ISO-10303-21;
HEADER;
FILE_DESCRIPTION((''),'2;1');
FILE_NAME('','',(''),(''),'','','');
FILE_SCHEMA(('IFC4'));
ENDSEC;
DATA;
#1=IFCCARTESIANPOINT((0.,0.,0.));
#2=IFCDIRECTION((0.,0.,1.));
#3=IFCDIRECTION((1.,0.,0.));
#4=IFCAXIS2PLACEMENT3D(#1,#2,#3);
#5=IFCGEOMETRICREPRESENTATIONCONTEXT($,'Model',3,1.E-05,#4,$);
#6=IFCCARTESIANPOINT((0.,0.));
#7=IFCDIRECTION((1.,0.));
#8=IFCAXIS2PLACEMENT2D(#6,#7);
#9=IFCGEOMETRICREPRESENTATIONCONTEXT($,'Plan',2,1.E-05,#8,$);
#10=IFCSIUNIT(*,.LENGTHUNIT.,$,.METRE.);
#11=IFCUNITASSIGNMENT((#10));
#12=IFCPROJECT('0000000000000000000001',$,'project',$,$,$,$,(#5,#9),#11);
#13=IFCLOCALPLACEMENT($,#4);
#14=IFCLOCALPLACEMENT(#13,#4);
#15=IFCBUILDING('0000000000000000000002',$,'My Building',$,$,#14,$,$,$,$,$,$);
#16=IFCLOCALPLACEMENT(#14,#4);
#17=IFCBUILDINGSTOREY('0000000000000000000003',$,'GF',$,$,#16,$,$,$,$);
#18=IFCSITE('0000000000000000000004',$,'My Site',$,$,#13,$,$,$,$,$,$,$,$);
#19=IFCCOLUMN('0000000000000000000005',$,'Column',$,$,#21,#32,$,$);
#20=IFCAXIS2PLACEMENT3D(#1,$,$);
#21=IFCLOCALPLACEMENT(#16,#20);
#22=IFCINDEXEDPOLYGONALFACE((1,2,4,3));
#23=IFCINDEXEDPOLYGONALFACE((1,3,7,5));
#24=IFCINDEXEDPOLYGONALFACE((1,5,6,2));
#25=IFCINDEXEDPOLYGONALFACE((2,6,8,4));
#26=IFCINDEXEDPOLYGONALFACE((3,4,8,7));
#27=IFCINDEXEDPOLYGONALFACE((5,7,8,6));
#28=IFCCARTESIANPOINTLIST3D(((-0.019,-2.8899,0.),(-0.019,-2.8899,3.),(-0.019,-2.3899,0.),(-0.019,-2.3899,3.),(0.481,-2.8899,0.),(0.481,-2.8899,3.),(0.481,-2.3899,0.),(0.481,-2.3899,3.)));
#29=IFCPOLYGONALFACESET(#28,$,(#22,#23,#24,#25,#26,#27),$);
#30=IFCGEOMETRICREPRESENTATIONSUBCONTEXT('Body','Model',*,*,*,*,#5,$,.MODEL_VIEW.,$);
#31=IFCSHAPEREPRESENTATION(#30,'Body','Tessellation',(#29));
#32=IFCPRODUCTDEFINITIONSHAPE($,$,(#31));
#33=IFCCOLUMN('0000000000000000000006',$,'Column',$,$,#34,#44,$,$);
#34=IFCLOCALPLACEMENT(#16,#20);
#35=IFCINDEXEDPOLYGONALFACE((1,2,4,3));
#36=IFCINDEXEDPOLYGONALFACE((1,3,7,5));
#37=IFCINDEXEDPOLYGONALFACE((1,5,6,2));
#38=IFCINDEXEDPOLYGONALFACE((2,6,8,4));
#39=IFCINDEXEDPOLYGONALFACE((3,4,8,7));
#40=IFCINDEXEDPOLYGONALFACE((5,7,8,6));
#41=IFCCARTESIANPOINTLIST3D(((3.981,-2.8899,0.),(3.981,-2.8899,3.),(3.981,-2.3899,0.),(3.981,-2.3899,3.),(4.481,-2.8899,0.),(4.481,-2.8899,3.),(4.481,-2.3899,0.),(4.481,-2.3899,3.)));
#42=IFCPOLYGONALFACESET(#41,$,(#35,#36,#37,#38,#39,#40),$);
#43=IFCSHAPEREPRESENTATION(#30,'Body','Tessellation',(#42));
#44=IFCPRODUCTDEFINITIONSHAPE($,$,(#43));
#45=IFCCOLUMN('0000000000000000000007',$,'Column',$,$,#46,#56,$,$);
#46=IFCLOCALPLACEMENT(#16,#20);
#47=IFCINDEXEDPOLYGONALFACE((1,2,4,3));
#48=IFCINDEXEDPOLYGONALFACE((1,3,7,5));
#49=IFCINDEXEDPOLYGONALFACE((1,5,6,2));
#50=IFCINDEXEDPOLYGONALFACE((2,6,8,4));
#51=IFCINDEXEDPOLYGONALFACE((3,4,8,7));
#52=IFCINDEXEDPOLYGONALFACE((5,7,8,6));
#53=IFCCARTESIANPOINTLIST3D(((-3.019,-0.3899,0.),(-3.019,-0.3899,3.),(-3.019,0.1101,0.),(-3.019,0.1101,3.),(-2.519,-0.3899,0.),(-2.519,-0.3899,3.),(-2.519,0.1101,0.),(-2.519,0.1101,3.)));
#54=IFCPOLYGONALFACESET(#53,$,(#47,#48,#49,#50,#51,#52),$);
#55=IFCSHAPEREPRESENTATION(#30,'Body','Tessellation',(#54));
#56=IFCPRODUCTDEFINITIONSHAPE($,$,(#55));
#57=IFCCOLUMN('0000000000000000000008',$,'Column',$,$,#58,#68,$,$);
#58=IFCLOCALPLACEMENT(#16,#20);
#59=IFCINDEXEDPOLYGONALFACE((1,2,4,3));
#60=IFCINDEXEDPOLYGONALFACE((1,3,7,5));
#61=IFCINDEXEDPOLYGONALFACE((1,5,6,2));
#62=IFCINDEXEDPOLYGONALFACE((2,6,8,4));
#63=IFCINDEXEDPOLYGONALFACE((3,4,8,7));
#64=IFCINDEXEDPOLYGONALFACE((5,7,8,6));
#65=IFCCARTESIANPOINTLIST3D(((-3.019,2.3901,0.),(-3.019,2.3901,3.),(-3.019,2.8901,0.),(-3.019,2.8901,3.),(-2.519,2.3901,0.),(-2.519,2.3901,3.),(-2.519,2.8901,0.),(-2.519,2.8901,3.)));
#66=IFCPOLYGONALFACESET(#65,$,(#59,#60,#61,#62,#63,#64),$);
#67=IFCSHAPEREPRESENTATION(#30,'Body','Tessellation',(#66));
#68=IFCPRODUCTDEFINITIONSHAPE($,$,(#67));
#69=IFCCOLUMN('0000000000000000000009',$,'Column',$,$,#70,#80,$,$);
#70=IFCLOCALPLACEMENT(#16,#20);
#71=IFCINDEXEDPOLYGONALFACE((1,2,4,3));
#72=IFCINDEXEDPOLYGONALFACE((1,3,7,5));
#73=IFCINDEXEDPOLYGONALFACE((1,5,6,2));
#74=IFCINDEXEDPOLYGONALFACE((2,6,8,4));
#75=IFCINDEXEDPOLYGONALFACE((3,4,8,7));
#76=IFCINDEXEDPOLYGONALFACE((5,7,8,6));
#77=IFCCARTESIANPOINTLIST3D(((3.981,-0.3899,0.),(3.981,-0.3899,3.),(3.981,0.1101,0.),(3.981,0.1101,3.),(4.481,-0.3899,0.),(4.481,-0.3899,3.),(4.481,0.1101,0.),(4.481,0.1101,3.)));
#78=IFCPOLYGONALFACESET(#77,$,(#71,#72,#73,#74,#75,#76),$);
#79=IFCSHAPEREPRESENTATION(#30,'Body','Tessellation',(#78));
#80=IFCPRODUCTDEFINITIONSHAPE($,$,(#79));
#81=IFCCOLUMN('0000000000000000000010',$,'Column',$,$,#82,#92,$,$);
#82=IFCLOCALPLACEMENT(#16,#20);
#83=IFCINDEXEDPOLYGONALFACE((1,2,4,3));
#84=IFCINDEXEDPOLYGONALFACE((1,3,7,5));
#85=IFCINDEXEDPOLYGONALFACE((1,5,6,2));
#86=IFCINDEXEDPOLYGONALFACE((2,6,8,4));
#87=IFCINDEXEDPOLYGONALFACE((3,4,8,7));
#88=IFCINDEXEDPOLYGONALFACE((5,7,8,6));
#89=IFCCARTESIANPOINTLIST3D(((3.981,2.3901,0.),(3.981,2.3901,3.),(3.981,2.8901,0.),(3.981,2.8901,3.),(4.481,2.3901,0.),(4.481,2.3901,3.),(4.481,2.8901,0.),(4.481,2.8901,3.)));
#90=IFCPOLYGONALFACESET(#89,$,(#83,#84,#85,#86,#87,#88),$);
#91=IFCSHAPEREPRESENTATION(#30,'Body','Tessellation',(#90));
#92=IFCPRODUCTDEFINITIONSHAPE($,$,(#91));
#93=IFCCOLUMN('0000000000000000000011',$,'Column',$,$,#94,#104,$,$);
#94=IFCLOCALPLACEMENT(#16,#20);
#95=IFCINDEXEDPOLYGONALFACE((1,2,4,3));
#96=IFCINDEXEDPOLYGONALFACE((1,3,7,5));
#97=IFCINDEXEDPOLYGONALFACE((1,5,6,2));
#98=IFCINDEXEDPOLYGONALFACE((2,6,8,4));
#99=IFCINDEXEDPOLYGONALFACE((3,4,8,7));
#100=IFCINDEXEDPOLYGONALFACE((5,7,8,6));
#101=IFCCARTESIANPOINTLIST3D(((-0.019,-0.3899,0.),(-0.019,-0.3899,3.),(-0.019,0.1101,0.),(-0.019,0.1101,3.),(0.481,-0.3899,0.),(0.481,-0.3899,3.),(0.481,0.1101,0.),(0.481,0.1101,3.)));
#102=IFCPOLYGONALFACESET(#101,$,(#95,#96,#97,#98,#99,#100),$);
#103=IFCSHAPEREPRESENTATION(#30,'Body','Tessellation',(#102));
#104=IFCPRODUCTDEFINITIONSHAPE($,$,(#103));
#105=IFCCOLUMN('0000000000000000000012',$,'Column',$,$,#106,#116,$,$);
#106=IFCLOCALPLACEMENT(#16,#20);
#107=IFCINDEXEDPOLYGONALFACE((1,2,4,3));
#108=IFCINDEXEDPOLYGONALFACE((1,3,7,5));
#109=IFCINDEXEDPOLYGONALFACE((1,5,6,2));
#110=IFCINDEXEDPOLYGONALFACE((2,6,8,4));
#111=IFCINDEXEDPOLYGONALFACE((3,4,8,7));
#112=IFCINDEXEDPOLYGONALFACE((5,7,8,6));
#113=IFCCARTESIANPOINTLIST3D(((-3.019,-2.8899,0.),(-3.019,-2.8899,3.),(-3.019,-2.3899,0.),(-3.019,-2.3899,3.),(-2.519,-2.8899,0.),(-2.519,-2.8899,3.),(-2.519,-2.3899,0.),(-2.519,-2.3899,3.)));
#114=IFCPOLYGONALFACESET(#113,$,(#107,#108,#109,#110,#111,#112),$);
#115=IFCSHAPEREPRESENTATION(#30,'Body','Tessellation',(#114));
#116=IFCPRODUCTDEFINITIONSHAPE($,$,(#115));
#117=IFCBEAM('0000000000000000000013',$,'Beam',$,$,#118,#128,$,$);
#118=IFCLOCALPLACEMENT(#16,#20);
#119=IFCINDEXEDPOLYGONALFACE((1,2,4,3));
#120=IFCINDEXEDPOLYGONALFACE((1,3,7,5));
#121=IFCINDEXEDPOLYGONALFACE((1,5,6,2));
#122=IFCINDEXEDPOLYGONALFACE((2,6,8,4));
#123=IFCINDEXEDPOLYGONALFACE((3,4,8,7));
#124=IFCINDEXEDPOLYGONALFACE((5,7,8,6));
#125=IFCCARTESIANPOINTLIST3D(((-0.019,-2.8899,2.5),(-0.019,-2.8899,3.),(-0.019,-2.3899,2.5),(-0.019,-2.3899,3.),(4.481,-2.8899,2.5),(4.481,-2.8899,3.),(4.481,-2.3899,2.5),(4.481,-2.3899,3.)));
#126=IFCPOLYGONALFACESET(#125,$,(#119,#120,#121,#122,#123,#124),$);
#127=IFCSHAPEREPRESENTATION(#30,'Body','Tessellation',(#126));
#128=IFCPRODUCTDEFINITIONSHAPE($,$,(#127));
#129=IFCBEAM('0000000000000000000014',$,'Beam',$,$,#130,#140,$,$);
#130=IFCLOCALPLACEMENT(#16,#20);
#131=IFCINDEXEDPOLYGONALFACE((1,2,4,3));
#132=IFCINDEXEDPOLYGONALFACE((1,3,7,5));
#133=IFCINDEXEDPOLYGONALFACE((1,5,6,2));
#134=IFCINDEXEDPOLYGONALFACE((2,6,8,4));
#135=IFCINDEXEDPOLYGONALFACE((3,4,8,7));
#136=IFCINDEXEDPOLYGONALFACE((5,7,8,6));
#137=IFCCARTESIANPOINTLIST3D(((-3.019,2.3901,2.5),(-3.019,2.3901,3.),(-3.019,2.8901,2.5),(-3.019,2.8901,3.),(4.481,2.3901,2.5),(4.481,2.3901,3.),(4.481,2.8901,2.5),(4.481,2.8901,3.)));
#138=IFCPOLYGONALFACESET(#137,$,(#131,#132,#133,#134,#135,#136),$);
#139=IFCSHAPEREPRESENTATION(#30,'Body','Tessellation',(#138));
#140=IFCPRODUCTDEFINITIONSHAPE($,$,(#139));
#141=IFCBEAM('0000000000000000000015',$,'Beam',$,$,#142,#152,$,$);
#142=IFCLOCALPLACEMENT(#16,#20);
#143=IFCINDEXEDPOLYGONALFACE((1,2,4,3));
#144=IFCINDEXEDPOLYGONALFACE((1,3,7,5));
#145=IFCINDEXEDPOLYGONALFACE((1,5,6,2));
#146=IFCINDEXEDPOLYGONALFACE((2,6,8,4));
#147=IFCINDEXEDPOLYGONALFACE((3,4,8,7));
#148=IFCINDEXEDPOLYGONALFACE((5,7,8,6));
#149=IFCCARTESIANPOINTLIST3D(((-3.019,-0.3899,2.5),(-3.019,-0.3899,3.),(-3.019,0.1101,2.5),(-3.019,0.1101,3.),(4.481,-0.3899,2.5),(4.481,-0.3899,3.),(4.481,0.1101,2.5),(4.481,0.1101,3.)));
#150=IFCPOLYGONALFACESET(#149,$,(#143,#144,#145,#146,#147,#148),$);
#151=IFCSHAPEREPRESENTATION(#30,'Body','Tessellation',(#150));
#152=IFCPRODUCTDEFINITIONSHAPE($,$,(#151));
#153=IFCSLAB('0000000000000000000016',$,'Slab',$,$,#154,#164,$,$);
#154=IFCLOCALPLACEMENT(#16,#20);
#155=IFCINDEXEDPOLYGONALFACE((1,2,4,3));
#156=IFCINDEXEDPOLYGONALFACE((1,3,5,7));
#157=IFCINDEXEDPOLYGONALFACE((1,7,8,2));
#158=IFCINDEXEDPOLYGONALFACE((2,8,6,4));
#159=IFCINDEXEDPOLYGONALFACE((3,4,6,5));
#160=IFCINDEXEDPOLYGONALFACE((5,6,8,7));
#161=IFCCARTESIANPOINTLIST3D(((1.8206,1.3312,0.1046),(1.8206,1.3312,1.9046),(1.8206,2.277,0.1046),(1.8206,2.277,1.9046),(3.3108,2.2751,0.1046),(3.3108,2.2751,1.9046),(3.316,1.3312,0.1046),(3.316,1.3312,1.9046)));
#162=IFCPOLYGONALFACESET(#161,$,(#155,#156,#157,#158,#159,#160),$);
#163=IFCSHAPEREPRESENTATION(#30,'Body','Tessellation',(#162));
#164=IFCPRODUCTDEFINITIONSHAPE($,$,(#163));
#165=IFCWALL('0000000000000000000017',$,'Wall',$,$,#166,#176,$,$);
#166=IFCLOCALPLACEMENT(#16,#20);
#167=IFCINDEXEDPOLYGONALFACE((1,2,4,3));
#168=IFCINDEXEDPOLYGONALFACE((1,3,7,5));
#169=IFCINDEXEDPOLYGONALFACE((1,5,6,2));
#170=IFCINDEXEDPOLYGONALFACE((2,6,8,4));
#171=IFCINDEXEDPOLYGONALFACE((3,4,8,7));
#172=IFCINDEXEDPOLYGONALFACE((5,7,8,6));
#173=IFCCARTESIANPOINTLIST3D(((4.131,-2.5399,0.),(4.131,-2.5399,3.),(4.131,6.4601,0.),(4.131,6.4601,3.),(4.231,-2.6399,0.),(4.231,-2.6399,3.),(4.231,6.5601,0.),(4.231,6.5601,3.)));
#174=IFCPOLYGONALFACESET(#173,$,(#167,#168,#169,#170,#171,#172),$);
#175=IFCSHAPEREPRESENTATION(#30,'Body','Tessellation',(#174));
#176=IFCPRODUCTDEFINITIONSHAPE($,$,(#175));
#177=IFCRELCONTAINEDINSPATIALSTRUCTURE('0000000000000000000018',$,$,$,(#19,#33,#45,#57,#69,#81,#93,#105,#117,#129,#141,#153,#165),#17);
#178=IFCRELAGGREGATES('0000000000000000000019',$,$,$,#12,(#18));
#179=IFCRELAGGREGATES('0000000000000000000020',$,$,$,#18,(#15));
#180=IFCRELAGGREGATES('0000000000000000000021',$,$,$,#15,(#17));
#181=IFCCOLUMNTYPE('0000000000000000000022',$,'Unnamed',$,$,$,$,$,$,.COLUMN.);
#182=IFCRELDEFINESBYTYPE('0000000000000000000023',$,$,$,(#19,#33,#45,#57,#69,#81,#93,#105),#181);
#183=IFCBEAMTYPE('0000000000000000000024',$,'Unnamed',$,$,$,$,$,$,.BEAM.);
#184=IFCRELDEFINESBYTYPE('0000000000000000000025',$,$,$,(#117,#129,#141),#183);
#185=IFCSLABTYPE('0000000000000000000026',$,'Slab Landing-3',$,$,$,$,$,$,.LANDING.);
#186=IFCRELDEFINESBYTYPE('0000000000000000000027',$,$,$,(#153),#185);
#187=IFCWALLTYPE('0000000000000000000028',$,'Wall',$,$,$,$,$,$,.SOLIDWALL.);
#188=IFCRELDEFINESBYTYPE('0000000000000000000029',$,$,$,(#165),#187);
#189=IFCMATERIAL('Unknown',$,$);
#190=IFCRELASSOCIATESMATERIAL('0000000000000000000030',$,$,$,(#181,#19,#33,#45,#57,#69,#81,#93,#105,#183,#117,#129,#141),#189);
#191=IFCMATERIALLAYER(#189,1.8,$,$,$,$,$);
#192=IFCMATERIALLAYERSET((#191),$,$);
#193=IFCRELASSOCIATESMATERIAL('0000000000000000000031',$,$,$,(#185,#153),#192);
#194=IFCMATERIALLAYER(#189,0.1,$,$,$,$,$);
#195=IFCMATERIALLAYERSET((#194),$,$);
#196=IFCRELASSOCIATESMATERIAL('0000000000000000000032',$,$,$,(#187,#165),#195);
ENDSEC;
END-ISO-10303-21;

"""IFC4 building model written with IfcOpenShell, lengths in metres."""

from ifc_helpers import new_model, si_unit, frame, origin_with_axes, origin_2d_with_axis, place, context, subcontext, project, spatial, line, indexed_curve, rectangle, outline, extrude, material, layer, layer_set, layer_usage, material_profile, profile_set, profile_usage, type_object, element, save


model = new_model("IFC4")

# Units and contexts
model_context = context("Model", 3, precision=1e-05, world=origin_with_axes())
plan_context = context("Plan", 2, precision=1e-05, world=origin_2d_with_axis())
body_context_1 = subcontext(model_context, "Body", "Model", "MODEL_VIEW")
ifc_project = project(units=[si_unit("LENGTHUNIT", "METRE")], contexts=[model_context, plan_context])

# Site, building, storey
site_placement = place(None, origin_with_axes())
site = spatial("IfcSite", under=ifc_project, at=site_placement, Name="My Site")
building_placement = place(site_placement, origin_with_axes())
building = spatial("IfcBuilding", under=site, at=building_placement, Name="My Building")
storey_placement = place(building_placement, origin_with_axes())
storey = spatial("IfcBuildingStorey", under=building, at=storey_placement, Name="GF")

# Columns
ifc_material = material(Name="Unknown")
ifc_material_profile_1 = material_profile(ifc_material, rectangle(XDim=0.5, YDim=0.5))
ifc_profile_set_1 = profile_set([ifc_material_profile_1])
ifc_profile_usage_1 = profile_usage(ifc_profile_set_1, cardinal=5)
column_type = type_object("IfcColumnType", Name="Unnamed", PredefinedType="COLUMN", material=ifc_profile_set_1)
column_1_placement = place(storey_placement, frame((0.231, -2.6399, 0.0), z_axis=(0.0, 0.0, 1.0), x_axis=(1.0, 0.0, 0.0)))
element("IfcColumn", 1, at=column_1_placement, inside=storey, type_object=column_type, material=ifc_profile_usage_1, Name="Column", context=body_context_1, shape_type="SweptSolid", body=[
    extrude(rectangle(XDim=0.5, YDim=0.5), origin_with_axes(), (0.0, 0.0, 1.0), 3.0),
])
ifc_profile_usage_2 = profile_usage(ifc_profile_set_1, cardinal=5)
column_2_placement = place(storey_placement, frame((4.231, -2.6399, 0.0), z_axis=(0.0, 0.0, 1.0), x_axis=(1.0, 0.0, 0.0)))
element("IfcColumn", 2, at=column_2_placement, inside=storey, type_object=column_type, material=ifc_profile_usage_2, Name="Column", context=body_context_1, shape_type="SweptSolid", body=[
    extrude(rectangle(XDim=0.5, YDim=0.5), origin_with_axes(), (0.0, 0.0, 1.0), 3.0),
])
ifc_profile_usage_3 = profile_usage(ifc_profile_set_1, cardinal=5)
column_3_placement = place(storey_placement, frame((-2.769, -0.1399, 0.0), z_axis=(0.0, 0.0, 1.0), x_axis=(1.0, 0.0, 0.0)))
element("IfcColumn", 3, at=column_3_placement, inside=storey, type_object=column_type, material=ifc_profile_usage_3, Name="Column", context=body_context_1, shape_type="SweptSolid", body=[
    extrude(rectangle(XDim=0.5, YDim=0.5), origin_with_axes(), (0.0, 0.0, 1.0), 3.0),
])
ifc_profile_usage_4 = profile_usage(ifc_profile_set_1, cardinal=5)
column_4_placement = place(storey_placement, frame((-2.769, 2.6401, 0.0), z_axis=(0.0, 0.0, 1.0), x_axis=(1.0, 0.0, 0.0)))
element("IfcColumn", 4, at=column_4_placement, inside=storey, type_object=column_type, material=ifc_profile_usage_4, Name="Column", context=body_context_1, shape_type="SweptSolid", body=[
    extrude(rectangle(XDim=0.5, YDim=0.5), origin_with_axes(), (0.0, 0.0, 1.0), 3.0),
])
ifc_profile_usage_5 = profile_usage(ifc_profile_set_1, cardinal=5)
column_5_placement = place(storey_placement, frame((4.231, -0.1399, 0.0), z_axis=(0.0, 0.0, 1.0), x_axis=(1.0, 0.0, 0.0)))
element("IfcColumn", 5, at=column_5_placement, inside=storey, type_object=column_type, material=ifc_profile_usage_5, Name="Column", context=body_context_1, shape_type="SweptSolid", body=[
    extrude(rectangle(XDim=0.5, YDim=0.5), origin_with_axes(), (0.0, 0.0, 1.0), 3.0),
])
ifc_profile_usage_6 = profile_usage(ifc_profile_set_1, cardinal=5)
column_6_placement = place(storey_placement, frame((4.231, 2.6401, 0.0), z_axis=(0.0, 0.0, 1.0), x_axis=(1.0, 0.0, 0.0)))
element("IfcColumn", 6, at=column_6_placement, inside=storey, type_object=column_type, material=ifc_profile_usage_6, Name="Column", context=body_context_1, shape_type="SweptSolid", body=[
    extrude(rectangle(XDim=0.5, YDim=0.5), origin_with_axes(), (0.0, 0.0, 1.0), 3.0),
])
ifc_profile_usage_7 = profile_usage(ifc_profile_set_1, cardinal=5)
column_7_placement = place(storey_placement, frame((0.231, -0.1399, 0.0), z_axis=(0.0, 0.0, 1.0), x_axis=(1.0, 0.0, 0.0)))
element("IfcColumn", 7, at=column_7_placement, inside=storey, type_object=column_type, material=ifc_profile_usage_7, Name="Column", context=body_context_1, shape_type="SweptSolid", body=[
    extrude(rectangle(XDim=0.5, YDim=0.5), origin_with_axes(), (0.0, 0.0, 1.0), 3.0),
])
ifc_profile_usage_8 = profile_usage(ifc_profile_set_1, cardinal=5)
column_8_placement = place(storey_placement, frame((-2.769, -2.6399, 0.0), z_axis=(0.0, 0.0, 1.0), x_axis=(1.0, 0.0, 0.0)))
element("IfcColumn", 8, at=column_8_placement, inside=storey, type_object=column_type, material=ifc_profile_usage_8, Name="Column", context=body_context_1, shape_type="SweptSolid", body=[
    extrude(rectangle(XDim=0.5, YDim=0.5), origin_with_axes(), (0.0, 0.0, 1.0), 3.0),
])

# Beams
ifc_material_profile_2 = material_profile(ifc_material, rectangle(XDim=0.5, YDim=0.5))
ifc_profile_set_2 = profile_set([ifc_material_profile_2])
ifc_profile_usage_9 = profile_usage(ifc_profile_set_2, cardinal=7)
beam_type = type_object("IfcBeamType", Name="Unnamed", PredefinedType="BEAM", material=ifc_profile_set_2)
beam_1_placement = place(storey_placement, frame((4.481, -2.8899, 3.0), z_axis=(-1.0, -0.000001, 0.000001), x_axis=(0.000001, -1.0, 0.0)))
element("IfcBeam", 9, at=beam_1_placement, inside=storey, type_object=beam_type, material=ifc_profile_usage_9, Name="Beam", context=body_context_1, shape_type="SweptSolid", body=[
    extrude(rectangle(XDim=0.5, YDim=0.5), frame((-0.25, -0.25, 0.0), z_axis=(0.0, 0.0, 1.0), x_axis=(1.0, 0.0, 0.0)), (0.0, 0.0, 1.0), 4.5),
])
ifc_profile_usage_10 = profile_usage(ifc_profile_set_2, cardinal=7)
beam_2_placement = place(storey_placement, frame((4.481, 2.3901, 3.0), z_axis=(-1.0, 0.0, 0.0), x_axis=(0.0, -1.0, 0.0)))
element("IfcBeam", 10, at=beam_2_placement, inside=storey, type_object=beam_type, material=ifc_profile_usage_10, Name="Beam", context=body_context_1, shape_type="SweptSolid", body=[
    extrude(rectangle(XDim=0.5, YDim=0.5), frame((-0.25, -0.25, 0.0), z_axis=(0.0, 0.0, 1.0), x_axis=(1.0, 0.0, 0.0)), (0.0, 0.0, 1.0), 7.5),
])
ifc_profile_usage_11 = profile_usage(ifc_profile_set_2, cardinal=7)
beam_3_placement = place(storey_placement, frame((-3.019, 0.1101, 3.0), z_axis=(1.0, 0.0, 0.0), x_axis=(0.0, 1.0, 0.0)))
element("IfcBeam", 11, at=beam_3_placement, inside=storey, type_object=beam_type, material=ifc_profile_usage_11, Name="Beam", context=body_context_1, shape_type="SweptSolid", body=[
    extrude(rectangle(XDim=0.5, YDim=0.5), frame((-0.25, -0.25, 0.0), z_axis=(0.0, 0.0, 1.0), x_axis=(1.0, 0.0, 0.0)), (0.0, 0.0, 1.0), 7.5),
])

# Slab
ifc_layer_1 = layer(ifc_material, 1.8)
ifc_layer_set_1 = layer_set([ifc_layer_1])
ifc_layer_usage_1 = layer_usage(ifc_layer_set_1, "AXIS3", "POSITIVE", -1.8)
slab_type_1 = type_object("IfcSlabType", Name="Slab Landing-3", PredefinedType="LANDING", material=ifc_layer_set_1)
slab_1_placement = place(storey_placement, frame((3.3108, 2.2751, 1.9046), z_axis=(0.0, 0.0, 1.0), x_axis=(1.0, 0.0, 0.0)))
element("IfcSlab", 12, at=slab_1_placement, inside=storey, type_object=slab_type_1, material=ifc_layer_usage_1, Name="Slab", context=body_context_1, shape_type="SweptSolid", body=[
    extrude(outline(indexed_curve([(0.0, 0.0), (0.0053, -0.9439), (-1.4901, -0.9439), (-1.4902, 0.0019), (0.0, 0.0)])), frame((0.0, 0.0, -1.8), z_axis=(0.0, 0.0, 1.0), x_axis=(1.0, 0.0, 0.0)), (0.0, 0.0, 1.0), 1.8),
])

# Shared definitions
ifc_layer_2 = layer(ifc_material, 0.1)
ifc_layer_set_2 = layer_set([ifc_layer_2])
wall_type = type_object("IfcWallType", Name="Wall", PredefinedType="SOLIDWALL", material=ifc_layer_set_2)

# Wall
ifc_layer_usage_2 = layer_usage(ifc_layer_set_2, "AXIS2", "POSITIVE", 0.0)
wall_1_placement = place(storey_placement, frame((4.231, -2.6399, 0.0), z_axis=(0.0, 0.0, 1.0), x_axis=(0.0, 1.0, 0.0)))
element("IfcWall", 13, at=wall_1_placement, inside=storey, type_object=wall_type, material=ifc_layer_usage_2, Name="Wall", context=body_context_1, shape_type="SweptSolid", body=[
    extrude(outline(indexed_curve([(0.0, 0.0), (0.1, 0.1), (9.1, 0.1), (9.2, 0.0)], segments=[line(1, 2, 3, 4, 1)])), origin_with_axes(), (0.0, 0.0, 1.0), 3.0),
])

save(model, "model.ifc")
